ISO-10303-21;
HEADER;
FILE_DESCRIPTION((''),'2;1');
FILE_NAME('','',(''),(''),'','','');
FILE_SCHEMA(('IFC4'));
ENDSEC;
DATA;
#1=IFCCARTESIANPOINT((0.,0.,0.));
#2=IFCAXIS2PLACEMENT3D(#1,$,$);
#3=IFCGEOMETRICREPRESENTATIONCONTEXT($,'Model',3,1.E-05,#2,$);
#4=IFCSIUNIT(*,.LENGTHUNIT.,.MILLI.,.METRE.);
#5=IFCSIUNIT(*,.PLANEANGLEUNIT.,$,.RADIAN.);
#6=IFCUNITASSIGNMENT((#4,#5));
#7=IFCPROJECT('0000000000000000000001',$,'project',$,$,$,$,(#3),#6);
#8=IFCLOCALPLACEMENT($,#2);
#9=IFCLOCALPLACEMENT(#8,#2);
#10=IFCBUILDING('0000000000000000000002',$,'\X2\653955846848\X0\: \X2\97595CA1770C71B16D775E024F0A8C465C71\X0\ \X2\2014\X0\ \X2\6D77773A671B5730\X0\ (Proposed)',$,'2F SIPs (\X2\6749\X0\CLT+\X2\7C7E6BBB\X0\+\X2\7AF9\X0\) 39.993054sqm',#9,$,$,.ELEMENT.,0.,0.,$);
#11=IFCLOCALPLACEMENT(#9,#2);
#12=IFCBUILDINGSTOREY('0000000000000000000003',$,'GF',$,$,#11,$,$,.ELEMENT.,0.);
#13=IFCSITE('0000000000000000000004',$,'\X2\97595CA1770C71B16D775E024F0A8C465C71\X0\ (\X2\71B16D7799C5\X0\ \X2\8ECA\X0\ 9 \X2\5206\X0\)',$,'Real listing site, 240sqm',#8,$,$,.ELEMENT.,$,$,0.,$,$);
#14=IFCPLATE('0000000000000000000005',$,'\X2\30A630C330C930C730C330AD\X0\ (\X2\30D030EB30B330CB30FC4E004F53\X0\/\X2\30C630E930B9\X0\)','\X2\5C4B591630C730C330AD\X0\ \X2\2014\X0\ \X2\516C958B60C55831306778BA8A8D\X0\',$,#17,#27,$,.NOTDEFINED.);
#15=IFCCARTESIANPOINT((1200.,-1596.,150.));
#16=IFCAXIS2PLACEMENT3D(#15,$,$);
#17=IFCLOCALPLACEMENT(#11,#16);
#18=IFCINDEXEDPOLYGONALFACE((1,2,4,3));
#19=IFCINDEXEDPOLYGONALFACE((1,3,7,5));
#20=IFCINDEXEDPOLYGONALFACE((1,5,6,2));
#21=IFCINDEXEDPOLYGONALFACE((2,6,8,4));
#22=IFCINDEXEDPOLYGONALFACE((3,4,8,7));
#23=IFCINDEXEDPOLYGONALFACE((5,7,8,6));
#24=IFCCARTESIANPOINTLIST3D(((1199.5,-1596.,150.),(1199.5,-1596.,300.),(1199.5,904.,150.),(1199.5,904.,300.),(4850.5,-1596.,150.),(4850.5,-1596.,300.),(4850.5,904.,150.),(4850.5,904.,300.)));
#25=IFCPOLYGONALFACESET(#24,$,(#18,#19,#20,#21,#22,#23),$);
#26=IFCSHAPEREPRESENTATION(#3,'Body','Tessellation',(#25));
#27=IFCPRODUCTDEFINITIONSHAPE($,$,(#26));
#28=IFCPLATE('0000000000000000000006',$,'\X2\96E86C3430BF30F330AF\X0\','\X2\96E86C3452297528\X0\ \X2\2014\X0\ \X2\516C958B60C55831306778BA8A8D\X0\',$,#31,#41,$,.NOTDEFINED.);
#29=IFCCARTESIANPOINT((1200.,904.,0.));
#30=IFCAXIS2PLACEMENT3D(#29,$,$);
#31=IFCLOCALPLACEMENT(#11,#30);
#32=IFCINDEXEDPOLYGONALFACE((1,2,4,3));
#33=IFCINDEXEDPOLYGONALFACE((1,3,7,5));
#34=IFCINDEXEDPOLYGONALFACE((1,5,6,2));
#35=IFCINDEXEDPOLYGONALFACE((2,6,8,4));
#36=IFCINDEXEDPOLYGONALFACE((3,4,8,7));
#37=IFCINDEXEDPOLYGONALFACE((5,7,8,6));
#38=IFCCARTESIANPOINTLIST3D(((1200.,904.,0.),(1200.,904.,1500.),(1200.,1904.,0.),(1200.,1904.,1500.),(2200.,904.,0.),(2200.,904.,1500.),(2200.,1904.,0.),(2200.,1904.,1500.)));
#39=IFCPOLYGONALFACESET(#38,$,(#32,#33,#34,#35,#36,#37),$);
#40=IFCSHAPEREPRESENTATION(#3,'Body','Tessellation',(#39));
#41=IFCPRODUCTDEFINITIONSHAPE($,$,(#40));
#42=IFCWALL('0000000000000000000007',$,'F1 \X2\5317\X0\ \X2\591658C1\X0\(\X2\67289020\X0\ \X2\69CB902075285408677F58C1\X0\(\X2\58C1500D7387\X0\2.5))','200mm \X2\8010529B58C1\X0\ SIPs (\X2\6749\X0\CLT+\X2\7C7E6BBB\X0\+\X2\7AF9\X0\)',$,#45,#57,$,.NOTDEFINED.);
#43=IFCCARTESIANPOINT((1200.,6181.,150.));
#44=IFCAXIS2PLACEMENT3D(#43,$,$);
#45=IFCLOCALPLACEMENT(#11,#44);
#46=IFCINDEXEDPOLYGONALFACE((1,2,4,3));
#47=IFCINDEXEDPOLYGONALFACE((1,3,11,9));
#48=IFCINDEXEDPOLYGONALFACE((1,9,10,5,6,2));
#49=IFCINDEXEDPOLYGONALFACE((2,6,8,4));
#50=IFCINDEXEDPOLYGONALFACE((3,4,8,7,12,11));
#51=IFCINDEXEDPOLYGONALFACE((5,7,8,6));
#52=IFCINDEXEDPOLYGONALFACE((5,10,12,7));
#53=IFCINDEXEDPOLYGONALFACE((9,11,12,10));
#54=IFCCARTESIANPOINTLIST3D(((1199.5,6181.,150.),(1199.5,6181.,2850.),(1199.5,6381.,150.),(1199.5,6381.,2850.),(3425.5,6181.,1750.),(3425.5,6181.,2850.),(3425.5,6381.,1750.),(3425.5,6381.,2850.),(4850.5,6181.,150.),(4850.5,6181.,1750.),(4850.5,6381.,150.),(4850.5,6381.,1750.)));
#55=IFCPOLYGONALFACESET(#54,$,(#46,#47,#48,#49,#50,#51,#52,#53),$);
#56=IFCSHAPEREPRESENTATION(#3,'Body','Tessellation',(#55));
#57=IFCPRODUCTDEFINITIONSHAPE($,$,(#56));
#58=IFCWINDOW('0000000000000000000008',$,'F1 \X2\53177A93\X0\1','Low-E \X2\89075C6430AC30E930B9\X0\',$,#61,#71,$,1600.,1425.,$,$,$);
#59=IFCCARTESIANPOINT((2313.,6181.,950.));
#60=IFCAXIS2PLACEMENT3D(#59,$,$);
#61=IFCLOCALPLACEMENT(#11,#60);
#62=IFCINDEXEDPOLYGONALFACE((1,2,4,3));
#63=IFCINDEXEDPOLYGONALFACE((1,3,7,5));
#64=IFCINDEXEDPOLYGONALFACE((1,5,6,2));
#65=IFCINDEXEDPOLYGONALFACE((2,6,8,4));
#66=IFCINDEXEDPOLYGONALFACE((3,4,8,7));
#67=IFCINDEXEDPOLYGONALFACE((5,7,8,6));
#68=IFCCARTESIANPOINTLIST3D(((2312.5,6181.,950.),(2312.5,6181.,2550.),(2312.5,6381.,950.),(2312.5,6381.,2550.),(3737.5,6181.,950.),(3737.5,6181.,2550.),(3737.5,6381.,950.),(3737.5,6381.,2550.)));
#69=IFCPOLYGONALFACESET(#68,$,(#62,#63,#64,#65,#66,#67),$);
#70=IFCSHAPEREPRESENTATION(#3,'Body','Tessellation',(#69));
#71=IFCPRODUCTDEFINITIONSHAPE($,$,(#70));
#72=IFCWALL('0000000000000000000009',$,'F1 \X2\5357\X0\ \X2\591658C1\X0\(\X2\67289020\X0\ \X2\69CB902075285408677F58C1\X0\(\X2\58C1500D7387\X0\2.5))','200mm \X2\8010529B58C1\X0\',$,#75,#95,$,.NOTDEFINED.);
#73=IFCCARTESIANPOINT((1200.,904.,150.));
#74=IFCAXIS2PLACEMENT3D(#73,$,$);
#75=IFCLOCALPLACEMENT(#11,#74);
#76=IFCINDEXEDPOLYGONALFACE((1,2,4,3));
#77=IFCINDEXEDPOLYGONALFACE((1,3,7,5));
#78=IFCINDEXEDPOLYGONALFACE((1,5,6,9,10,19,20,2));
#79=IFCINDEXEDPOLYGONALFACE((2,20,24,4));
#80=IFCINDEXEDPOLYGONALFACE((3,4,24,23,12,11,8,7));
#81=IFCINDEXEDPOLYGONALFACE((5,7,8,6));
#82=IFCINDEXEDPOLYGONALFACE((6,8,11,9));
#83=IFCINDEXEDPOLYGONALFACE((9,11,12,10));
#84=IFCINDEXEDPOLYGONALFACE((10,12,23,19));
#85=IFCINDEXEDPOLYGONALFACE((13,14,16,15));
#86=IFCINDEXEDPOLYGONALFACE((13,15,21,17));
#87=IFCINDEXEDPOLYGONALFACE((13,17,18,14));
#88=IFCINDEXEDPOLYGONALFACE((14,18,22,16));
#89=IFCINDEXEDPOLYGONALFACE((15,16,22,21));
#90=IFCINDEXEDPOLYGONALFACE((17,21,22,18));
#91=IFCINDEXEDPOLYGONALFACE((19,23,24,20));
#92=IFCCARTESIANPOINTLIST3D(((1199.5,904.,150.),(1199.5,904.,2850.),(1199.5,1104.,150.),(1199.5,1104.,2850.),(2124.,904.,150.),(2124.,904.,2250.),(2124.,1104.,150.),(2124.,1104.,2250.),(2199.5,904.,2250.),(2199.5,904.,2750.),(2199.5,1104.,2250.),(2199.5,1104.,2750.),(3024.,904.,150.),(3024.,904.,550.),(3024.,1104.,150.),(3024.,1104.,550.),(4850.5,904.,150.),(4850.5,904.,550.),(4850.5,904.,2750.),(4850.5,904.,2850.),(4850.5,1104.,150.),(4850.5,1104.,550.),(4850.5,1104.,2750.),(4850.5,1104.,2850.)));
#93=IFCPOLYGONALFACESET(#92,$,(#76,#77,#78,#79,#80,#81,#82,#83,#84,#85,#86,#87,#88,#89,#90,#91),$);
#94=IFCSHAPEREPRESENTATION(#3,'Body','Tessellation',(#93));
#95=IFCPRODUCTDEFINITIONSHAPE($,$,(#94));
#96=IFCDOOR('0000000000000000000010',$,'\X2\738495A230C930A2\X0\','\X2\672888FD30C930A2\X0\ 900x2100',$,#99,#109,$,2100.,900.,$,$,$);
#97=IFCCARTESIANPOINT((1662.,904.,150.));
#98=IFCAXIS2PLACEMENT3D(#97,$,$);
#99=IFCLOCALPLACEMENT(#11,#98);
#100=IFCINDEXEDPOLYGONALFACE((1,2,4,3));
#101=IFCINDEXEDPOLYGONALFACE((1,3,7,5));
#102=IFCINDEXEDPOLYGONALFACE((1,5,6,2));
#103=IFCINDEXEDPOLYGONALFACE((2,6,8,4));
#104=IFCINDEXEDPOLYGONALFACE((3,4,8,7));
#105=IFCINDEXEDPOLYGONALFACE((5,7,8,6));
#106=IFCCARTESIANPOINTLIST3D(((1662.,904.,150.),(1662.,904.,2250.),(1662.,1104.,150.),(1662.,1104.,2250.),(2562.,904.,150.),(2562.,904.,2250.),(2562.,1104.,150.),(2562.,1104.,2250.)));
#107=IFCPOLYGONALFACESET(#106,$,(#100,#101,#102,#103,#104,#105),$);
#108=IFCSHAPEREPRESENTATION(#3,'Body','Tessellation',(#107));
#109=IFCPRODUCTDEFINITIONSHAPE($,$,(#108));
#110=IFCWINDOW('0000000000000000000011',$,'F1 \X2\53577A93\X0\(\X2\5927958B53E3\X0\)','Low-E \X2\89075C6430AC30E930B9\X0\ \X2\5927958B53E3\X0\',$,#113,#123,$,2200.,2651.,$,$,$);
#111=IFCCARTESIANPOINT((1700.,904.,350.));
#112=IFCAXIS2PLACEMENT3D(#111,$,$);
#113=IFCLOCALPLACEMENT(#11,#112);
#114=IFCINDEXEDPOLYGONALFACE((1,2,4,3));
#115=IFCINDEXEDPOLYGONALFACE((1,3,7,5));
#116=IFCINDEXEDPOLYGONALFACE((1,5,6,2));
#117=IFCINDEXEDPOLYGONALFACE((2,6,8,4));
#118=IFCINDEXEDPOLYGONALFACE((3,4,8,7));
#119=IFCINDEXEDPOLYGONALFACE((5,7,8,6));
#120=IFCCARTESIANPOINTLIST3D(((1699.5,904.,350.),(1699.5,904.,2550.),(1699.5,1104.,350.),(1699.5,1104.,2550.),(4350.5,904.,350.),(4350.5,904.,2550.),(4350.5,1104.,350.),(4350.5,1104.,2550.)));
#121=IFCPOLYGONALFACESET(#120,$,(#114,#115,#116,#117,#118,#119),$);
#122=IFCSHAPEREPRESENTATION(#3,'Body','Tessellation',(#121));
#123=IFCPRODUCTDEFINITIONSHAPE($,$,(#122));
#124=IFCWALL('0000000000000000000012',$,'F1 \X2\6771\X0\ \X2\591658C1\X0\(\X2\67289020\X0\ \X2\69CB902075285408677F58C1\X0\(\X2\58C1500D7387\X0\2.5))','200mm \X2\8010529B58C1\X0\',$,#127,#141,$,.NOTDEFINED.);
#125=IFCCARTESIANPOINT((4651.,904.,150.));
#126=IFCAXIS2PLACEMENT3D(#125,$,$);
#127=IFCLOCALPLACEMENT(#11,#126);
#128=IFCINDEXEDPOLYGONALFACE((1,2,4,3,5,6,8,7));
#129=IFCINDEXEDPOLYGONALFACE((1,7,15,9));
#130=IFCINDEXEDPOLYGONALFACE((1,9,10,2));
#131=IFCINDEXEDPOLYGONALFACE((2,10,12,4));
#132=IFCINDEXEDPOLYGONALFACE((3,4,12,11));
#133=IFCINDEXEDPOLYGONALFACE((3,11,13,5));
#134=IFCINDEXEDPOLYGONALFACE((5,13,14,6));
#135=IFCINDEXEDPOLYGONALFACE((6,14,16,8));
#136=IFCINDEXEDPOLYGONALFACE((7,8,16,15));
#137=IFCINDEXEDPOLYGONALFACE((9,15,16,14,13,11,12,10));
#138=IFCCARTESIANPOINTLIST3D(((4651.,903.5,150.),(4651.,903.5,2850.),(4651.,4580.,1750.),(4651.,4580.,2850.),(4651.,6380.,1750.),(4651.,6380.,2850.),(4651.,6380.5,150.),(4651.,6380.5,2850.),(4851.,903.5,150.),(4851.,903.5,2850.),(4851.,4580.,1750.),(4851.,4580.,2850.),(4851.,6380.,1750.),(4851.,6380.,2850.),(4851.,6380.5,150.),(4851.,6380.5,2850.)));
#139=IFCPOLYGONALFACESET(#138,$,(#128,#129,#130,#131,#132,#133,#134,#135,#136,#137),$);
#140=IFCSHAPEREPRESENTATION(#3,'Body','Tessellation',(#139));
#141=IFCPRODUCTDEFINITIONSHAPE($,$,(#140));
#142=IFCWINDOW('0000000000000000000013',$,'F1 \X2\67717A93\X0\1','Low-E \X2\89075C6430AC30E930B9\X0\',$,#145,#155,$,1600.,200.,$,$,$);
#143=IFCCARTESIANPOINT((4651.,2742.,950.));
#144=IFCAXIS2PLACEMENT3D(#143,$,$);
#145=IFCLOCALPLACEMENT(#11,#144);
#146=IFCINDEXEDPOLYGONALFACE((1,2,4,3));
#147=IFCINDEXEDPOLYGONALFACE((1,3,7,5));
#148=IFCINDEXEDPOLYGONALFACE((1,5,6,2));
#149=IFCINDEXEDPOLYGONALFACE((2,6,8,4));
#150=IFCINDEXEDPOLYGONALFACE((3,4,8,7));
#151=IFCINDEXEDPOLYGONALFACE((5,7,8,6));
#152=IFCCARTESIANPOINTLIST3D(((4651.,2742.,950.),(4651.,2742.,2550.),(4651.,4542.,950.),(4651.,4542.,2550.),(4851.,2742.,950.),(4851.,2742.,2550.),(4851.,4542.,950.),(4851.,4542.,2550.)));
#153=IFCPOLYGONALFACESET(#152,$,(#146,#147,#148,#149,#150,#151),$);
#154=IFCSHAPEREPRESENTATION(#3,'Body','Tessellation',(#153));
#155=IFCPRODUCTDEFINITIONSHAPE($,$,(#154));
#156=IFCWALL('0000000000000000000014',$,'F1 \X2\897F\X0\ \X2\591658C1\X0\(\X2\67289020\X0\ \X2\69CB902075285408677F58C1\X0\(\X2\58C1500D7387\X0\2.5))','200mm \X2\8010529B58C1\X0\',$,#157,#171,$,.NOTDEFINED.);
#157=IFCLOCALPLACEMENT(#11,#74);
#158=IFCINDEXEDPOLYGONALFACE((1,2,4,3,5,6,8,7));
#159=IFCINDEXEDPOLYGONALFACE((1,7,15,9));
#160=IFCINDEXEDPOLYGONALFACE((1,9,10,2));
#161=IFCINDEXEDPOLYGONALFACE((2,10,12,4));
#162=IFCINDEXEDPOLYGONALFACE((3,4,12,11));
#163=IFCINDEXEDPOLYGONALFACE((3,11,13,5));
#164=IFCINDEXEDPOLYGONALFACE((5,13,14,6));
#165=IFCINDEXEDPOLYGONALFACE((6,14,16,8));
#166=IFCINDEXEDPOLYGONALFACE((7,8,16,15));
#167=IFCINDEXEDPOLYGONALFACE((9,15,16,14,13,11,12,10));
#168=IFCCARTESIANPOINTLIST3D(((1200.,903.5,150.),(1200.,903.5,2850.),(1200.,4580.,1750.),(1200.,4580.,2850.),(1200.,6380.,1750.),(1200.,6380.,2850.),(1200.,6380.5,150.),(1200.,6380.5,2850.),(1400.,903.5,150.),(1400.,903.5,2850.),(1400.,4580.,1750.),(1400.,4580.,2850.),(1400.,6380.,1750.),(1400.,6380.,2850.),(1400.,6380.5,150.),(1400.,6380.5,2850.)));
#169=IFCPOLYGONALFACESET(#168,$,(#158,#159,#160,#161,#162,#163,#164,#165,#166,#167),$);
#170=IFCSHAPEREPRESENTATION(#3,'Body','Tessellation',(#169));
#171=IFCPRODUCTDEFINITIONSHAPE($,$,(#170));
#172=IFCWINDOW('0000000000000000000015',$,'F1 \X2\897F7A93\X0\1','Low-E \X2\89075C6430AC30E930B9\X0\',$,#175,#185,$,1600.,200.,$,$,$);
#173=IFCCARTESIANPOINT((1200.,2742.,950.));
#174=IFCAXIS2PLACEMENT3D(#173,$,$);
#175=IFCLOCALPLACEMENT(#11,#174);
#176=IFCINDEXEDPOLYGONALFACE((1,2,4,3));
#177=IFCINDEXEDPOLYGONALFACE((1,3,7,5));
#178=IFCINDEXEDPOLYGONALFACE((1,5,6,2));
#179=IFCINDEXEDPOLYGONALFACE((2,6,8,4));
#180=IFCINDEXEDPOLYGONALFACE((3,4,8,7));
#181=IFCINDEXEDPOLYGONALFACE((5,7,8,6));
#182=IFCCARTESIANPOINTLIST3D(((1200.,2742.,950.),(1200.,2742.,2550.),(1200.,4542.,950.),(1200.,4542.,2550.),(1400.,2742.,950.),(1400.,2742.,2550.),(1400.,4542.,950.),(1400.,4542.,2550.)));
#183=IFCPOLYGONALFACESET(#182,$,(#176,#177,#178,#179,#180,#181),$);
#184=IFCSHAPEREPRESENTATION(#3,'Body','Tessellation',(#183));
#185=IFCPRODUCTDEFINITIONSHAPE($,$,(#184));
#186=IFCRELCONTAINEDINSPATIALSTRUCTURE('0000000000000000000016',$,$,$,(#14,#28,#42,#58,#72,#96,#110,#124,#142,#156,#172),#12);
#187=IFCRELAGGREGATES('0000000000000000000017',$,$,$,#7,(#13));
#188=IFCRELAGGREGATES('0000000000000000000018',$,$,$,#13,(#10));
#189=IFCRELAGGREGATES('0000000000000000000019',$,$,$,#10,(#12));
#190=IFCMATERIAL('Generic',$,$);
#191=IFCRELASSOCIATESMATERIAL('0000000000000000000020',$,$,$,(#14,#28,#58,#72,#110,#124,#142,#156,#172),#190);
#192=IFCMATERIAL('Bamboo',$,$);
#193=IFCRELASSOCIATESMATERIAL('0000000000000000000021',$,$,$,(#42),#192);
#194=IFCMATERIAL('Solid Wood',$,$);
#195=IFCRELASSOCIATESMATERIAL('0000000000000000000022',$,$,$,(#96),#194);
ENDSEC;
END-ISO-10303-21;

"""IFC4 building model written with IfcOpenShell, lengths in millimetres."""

from ifc_helpers import new_model, si_unit, frame, frame_2d, origin, place, context, project, spatial, rectangle, extrude, material, element, fill, save


model = new_model("IFC4")

# Units and contexts
model_context = context("Model", 3, precision=1e-05, world=origin())
ifc_project = project(units=[si_unit("LENGTHUNIT", "METRE", prefix="MILLI"), si_unit("PLANEANGLEUNIT", "RADIAN")], contexts=[model_context])

# Site, building, storey
site_placement = place(None, origin())
site = spatial("IfcSite", under=ifc_project, at=site_placement, Name="静岡県熱海市伊豆山 (熱海駅 車 9 分)", ObjectType="Real listing site, 240sqm", CompositionType="ELEMENT", RefElevation=0.0)
building_placement = place(site_placement, origin())
building = spatial("IfcBuilding", under=site, at=building_placement, Name="改善案: 静岡県熱海市伊豆山 — 海眺望地 (Proposed)", ObjectType="2F SIPs (杉CLT+籾殻+竹) 39.993054sqm", CompositionType="ELEMENT", ElevationOfRefHeight=0.0, ElevationOfTerrain=0.0)
storey_placement = place(building_placement, origin())
storey = spatial("IfcBuildingStorey", under=building, at=storey_placement, Name="GF", CompositionType="ELEMENT", Elevation=0.0)

# Shared definitions
ifc_material_1 = material(Name="Generic")

# Plates
plate_1_placement = place(storey_placement, frame((1200.0, -1596.0, 150.0)))
element("IfcPlate", 1, at=plate_1_placement, inside=storey, material=ifc_material_1, Name="ウッドデッキ (バルコニー一体/テラス)", Description="屋外デッキ — 公開情報で確認", PredefinedType="NOTDEFINED", context=model_context, shape_type="SweptSolid", body=[
    extrude(rectangle(XDim=3651.0, YDim=2500.0, at=frame_2d((1825.0, 1250.0))), frame((1200.0, -1596.0, 150.0)), (0.0, 0.0, 1.0), 150.0),
])
plate_2_placement = place(storey_placement, frame((1200.0, 904.0, 0.0)))
element("IfcPlate", 2, at=plate_2_placement, inside=storey, material=ifc_material_1, Name="雨水タンク", Description="雨水利用 — 公開情報で確認", PredefinedType="NOTDEFINED", context=model_context, shape_type="SweptSolid", body=[
    extrude(rectangle(XDim=1000.0, YDim=1000.0, at=frame_2d((500.0, 500.0))), frame((1200.0, 904.0, 0.0)), (0.0, 0.0, 1.0), 1500.0),
])

# Wall, opening, window
ifc_material_2 = material(Name="Bamboo")
wall_1_placement = place(storey_placement, frame((1200.0, 6181.0, 150.0)))
wall_1 = element("IfcWall", 3, at=wall_1_placement, inside=storey, material=ifc_material_2, Name="F1 北 外壁(木造 構造用合板壁(壁倍率2.5))", Description="200mm 耐力壁 SIPs (杉CLT+籾殻+竹)", PredefinedType="NOTDEFINED", context=model_context, shape_type="SweptSolid", body=[
    extrude(rectangle(XDim=3651.0, YDim=200.0, at=frame_2d((1825.0, 100.0))), frame((1200.0, 6181.0, 150.0)), (0.0, 0.0, 1.0), 2700.0),
])
opening_1_placement = place(storey_placement, frame((2313.0, 6181.0, 950.0)))
opening_1 = element("IfcOpeningElement", 4, at=opening_1_placement, cuts=wall_1, PredefinedType="NOTDEFINED", context=model_context, shape_type="SweptSolid", body=[
    extrude(rectangle(XDim=1425.0, YDim=200.0, at=frame_2d((712.0, 100.0))), frame((2313.0, 6181.0, 950.0)), (0.0, 0.0, 1.0), 1600.0),
])
window_1_placement = place(storey_placement, frame((2313.0, 6181.0, 950.0)))
window_1 = element("IfcWindow", 5, at=window_1_placement, inside=storey, material=ifc_material_1, Name="F1 北窓1", Description="Low-E 複層ガラス", OverallHeight=1600.0, OverallWidth=1425.0, context=model_context, shape_type="SweptSolid", body=[
    extrude(rectangle(XDim=1425.0, YDim=200.0, at=frame_2d((712.0, 100.0))), frame((2313.0, 6181.0, 950.0)), (0.0, 0.0, 1.0), 1600.0),
])
fill(opening_1, window_1)

# Wall, openings, door, window
wall_2_placement = place(storey_placement, frame((1200.0, 904.0, 150.0)))
wall_2 = element("IfcWall", 6, at=wall_2_placement, inside=storey, material=ifc_material_1, Name="F1 南 外壁(木造 構造用合板壁(壁倍率2.5))", Description="200mm 耐力壁", PredefinedType="NOTDEFINED", context=model_context, shape_type="SweptSolid", body=[
    extrude(rectangle(XDim=3651.0, YDim=200.0, at=frame_2d((1825.0, 100.0))), frame((1200.0, 904.0, 150.0)), (0.0, 0.0, 1.0), 2700.0),
])
opening_2_placement = place(storey_placement, frame((1662.0, 904.0, 150.0)))
opening_2 = element("IfcOpeningElement", 7, at=opening_2_placement, cuts=wall_2, PredefinedType="NOTDEFINED", context=model_context, shape_type="SweptSolid", body=[
    extrude(rectangle(XDim=900.0, YDim=200.0, at=frame_2d((450.0, 100.0))), frame((1662.0, 904.0, 150.0)), (0.0, 0.0, 1.0), 2100.0),
])
opening_3_placement = place(storey_placement, frame((1700.0, 904.0, 350.0)))
opening_3 = element("IfcOpeningElement", 8, at=opening_3_placement, cuts=wall_2, PredefinedType="NOTDEFINED", context=model_context, shape_type="SweptSolid", body=[
    extrude(rectangle(XDim=2651.0, YDim=200.0, at=frame_2d((1325.0, 100.0))), frame((1700.0, 904.0, 350.0)), (0.0, 0.0, 1.0), 2200.0),
])
ifc_material_3 = material(Name="Solid Wood")
door_placement = place(storey_placement, frame((1662.0, 904.0, 150.0)))
door = element("IfcDoor", 9, at=door_placement, inside=storey, material=ifc_material_3, Name="玄関ドア", Description="木製ドア 900x2100", OverallHeight=2100.0, OverallWidth=900.0, context=model_context, shape_type="SweptSolid", body=[
    extrude(rectangle(XDim=900.0, YDim=200.0, at=frame_2d((450.0, 100.0))), frame((1662.0, 904.0, 150.0)), (0.0, 0.0, 1.0), 2100.0),
])
fill(opening_2, door)
window_2_placement = place(storey_placement, frame((1700.0, 904.0, 350.0)))
window_2 = element("IfcWindow", 10, at=window_2_placement, inside=storey, material=ifc_material_1, Name="F1 南窓(大開口)", Description="Low-E 複層ガラス 大開口", OverallHeight=2200.0, OverallWidth=2651.0, context=model_context, shape_type="SweptSolid", body=[
    extrude(rectangle(XDim=2651.0, YDim=200.0, at=frame_2d((1325.0, 100.0))), frame((1700.0, 904.0, 350.0)), (0.0, 0.0, 1.0), 2200.0),
])
fill(opening_3, window_2)

# Walls, openings, windows
wall_3_placement = place(storey_placement, frame((4651.0, 904.0, 150.0)))
wall_3 = element("IfcWall", 11, at=wall_3_placement, inside=storey, material=ifc_material_1, Name="F1 東 外壁(木造 構造用合板壁(壁倍率2.5))", Description="200mm 耐力壁", PredefinedType="NOTDEFINED", context=model_context, shape_type="SweptSolid", body=[
    extrude(rectangle(XDim=200.0, YDim=5477.0, at=frame_2d((100.0, 2738.0))), frame((4651.0, 904.0, 150.0)), (0.0, 0.0, 1.0), 2700.0),
])
opening_4_placement = place(storey_placement, frame((4651.0, 2742.0, 950.0)))
opening_4 = element("IfcOpeningElement", 12, at=opening_4_placement, cuts=wall_3, PredefinedType="NOTDEFINED", context=model_context, shape_type="SweptSolid", body=[
    extrude(rectangle(XDim=200.0, YDim=1800.0, at=frame_2d((100.0, 900.0))), frame((4651.0, 2742.0, 950.0)), (0.0, 0.0, 1.0), 1600.0),
])
window_3_placement = place(storey_placement, frame((4651.0, 2742.0, 950.0)))
window_3 = element("IfcWindow", 13, at=window_3_placement, inside=storey, material=ifc_material_1, Name="F1 東窓1", Description="Low-E 複層ガラス", OverallHeight=1600.0, OverallWidth=200.0, context=model_context, shape_type="SweptSolid", body=[
    extrude(rectangle(XDim=200.0, YDim=1800.0, at=frame_2d((100.0, 900.0))), frame((4651.0, 2742.0, 950.0)), (0.0, 0.0, 1.0), 1600.0),
])
fill(opening_4, window_3)
wall_4_placement = place(storey_placement, frame((1200.0, 904.0, 150.0)))
wall_4 = element("IfcWall", 14, at=wall_4_placement, inside=storey, material=ifc_material_1, Name="F1 西 外壁(木造 構造用合板壁(壁倍率2.5))", Description="200mm 耐力壁", PredefinedType="NOTDEFINED", context=model_context, shape_type="SweptSolid", body=[
    extrude(rectangle(XDim=200.0, YDim=5477.0, at=frame_2d((100.0, 2738.0))), frame((1200.0, 904.0, 150.0)), (0.0, 0.0, 1.0), 2700.0),
])
opening_5_placement = place(storey_placement, frame((1200.0, 2742.0, 950.0)))
opening_5 = element("IfcOpeningElement", 15, at=opening_5_placement, cuts=wall_4, PredefinedType="NOTDEFINED", context=model_context, shape_type="SweptSolid", body=[
    extrude(rectangle(XDim=200.0, YDim=1800.0, at=frame_2d((100.0, 900.0))), frame((1200.0, 2742.0, 950.0)), (0.0, 0.0, 1.0), 1600.0),
])
window_4_placement = place(storey_placement, frame((1200.0, 2742.0, 950.0)))
window_4 = element("IfcWindow", 16, at=window_4_placement, inside=storey, material=ifc_material_1, Name="F1 西窓1", Description="Low-E 複層ガラス", OverallHeight=1600.0, OverallWidth=200.0, context=model_context, shape_type="SweptSolid", body=[
    extrude(rectangle(XDim=200.0, YDim=1800.0, at=frame_2d((100.0, 900.0))), frame((1200.0, 2742.0, 950.0)), (0.0, 0.0, 1.0), 1600.0),
])
fill(opening_5, window_4)

save(model, "model.ifc")
